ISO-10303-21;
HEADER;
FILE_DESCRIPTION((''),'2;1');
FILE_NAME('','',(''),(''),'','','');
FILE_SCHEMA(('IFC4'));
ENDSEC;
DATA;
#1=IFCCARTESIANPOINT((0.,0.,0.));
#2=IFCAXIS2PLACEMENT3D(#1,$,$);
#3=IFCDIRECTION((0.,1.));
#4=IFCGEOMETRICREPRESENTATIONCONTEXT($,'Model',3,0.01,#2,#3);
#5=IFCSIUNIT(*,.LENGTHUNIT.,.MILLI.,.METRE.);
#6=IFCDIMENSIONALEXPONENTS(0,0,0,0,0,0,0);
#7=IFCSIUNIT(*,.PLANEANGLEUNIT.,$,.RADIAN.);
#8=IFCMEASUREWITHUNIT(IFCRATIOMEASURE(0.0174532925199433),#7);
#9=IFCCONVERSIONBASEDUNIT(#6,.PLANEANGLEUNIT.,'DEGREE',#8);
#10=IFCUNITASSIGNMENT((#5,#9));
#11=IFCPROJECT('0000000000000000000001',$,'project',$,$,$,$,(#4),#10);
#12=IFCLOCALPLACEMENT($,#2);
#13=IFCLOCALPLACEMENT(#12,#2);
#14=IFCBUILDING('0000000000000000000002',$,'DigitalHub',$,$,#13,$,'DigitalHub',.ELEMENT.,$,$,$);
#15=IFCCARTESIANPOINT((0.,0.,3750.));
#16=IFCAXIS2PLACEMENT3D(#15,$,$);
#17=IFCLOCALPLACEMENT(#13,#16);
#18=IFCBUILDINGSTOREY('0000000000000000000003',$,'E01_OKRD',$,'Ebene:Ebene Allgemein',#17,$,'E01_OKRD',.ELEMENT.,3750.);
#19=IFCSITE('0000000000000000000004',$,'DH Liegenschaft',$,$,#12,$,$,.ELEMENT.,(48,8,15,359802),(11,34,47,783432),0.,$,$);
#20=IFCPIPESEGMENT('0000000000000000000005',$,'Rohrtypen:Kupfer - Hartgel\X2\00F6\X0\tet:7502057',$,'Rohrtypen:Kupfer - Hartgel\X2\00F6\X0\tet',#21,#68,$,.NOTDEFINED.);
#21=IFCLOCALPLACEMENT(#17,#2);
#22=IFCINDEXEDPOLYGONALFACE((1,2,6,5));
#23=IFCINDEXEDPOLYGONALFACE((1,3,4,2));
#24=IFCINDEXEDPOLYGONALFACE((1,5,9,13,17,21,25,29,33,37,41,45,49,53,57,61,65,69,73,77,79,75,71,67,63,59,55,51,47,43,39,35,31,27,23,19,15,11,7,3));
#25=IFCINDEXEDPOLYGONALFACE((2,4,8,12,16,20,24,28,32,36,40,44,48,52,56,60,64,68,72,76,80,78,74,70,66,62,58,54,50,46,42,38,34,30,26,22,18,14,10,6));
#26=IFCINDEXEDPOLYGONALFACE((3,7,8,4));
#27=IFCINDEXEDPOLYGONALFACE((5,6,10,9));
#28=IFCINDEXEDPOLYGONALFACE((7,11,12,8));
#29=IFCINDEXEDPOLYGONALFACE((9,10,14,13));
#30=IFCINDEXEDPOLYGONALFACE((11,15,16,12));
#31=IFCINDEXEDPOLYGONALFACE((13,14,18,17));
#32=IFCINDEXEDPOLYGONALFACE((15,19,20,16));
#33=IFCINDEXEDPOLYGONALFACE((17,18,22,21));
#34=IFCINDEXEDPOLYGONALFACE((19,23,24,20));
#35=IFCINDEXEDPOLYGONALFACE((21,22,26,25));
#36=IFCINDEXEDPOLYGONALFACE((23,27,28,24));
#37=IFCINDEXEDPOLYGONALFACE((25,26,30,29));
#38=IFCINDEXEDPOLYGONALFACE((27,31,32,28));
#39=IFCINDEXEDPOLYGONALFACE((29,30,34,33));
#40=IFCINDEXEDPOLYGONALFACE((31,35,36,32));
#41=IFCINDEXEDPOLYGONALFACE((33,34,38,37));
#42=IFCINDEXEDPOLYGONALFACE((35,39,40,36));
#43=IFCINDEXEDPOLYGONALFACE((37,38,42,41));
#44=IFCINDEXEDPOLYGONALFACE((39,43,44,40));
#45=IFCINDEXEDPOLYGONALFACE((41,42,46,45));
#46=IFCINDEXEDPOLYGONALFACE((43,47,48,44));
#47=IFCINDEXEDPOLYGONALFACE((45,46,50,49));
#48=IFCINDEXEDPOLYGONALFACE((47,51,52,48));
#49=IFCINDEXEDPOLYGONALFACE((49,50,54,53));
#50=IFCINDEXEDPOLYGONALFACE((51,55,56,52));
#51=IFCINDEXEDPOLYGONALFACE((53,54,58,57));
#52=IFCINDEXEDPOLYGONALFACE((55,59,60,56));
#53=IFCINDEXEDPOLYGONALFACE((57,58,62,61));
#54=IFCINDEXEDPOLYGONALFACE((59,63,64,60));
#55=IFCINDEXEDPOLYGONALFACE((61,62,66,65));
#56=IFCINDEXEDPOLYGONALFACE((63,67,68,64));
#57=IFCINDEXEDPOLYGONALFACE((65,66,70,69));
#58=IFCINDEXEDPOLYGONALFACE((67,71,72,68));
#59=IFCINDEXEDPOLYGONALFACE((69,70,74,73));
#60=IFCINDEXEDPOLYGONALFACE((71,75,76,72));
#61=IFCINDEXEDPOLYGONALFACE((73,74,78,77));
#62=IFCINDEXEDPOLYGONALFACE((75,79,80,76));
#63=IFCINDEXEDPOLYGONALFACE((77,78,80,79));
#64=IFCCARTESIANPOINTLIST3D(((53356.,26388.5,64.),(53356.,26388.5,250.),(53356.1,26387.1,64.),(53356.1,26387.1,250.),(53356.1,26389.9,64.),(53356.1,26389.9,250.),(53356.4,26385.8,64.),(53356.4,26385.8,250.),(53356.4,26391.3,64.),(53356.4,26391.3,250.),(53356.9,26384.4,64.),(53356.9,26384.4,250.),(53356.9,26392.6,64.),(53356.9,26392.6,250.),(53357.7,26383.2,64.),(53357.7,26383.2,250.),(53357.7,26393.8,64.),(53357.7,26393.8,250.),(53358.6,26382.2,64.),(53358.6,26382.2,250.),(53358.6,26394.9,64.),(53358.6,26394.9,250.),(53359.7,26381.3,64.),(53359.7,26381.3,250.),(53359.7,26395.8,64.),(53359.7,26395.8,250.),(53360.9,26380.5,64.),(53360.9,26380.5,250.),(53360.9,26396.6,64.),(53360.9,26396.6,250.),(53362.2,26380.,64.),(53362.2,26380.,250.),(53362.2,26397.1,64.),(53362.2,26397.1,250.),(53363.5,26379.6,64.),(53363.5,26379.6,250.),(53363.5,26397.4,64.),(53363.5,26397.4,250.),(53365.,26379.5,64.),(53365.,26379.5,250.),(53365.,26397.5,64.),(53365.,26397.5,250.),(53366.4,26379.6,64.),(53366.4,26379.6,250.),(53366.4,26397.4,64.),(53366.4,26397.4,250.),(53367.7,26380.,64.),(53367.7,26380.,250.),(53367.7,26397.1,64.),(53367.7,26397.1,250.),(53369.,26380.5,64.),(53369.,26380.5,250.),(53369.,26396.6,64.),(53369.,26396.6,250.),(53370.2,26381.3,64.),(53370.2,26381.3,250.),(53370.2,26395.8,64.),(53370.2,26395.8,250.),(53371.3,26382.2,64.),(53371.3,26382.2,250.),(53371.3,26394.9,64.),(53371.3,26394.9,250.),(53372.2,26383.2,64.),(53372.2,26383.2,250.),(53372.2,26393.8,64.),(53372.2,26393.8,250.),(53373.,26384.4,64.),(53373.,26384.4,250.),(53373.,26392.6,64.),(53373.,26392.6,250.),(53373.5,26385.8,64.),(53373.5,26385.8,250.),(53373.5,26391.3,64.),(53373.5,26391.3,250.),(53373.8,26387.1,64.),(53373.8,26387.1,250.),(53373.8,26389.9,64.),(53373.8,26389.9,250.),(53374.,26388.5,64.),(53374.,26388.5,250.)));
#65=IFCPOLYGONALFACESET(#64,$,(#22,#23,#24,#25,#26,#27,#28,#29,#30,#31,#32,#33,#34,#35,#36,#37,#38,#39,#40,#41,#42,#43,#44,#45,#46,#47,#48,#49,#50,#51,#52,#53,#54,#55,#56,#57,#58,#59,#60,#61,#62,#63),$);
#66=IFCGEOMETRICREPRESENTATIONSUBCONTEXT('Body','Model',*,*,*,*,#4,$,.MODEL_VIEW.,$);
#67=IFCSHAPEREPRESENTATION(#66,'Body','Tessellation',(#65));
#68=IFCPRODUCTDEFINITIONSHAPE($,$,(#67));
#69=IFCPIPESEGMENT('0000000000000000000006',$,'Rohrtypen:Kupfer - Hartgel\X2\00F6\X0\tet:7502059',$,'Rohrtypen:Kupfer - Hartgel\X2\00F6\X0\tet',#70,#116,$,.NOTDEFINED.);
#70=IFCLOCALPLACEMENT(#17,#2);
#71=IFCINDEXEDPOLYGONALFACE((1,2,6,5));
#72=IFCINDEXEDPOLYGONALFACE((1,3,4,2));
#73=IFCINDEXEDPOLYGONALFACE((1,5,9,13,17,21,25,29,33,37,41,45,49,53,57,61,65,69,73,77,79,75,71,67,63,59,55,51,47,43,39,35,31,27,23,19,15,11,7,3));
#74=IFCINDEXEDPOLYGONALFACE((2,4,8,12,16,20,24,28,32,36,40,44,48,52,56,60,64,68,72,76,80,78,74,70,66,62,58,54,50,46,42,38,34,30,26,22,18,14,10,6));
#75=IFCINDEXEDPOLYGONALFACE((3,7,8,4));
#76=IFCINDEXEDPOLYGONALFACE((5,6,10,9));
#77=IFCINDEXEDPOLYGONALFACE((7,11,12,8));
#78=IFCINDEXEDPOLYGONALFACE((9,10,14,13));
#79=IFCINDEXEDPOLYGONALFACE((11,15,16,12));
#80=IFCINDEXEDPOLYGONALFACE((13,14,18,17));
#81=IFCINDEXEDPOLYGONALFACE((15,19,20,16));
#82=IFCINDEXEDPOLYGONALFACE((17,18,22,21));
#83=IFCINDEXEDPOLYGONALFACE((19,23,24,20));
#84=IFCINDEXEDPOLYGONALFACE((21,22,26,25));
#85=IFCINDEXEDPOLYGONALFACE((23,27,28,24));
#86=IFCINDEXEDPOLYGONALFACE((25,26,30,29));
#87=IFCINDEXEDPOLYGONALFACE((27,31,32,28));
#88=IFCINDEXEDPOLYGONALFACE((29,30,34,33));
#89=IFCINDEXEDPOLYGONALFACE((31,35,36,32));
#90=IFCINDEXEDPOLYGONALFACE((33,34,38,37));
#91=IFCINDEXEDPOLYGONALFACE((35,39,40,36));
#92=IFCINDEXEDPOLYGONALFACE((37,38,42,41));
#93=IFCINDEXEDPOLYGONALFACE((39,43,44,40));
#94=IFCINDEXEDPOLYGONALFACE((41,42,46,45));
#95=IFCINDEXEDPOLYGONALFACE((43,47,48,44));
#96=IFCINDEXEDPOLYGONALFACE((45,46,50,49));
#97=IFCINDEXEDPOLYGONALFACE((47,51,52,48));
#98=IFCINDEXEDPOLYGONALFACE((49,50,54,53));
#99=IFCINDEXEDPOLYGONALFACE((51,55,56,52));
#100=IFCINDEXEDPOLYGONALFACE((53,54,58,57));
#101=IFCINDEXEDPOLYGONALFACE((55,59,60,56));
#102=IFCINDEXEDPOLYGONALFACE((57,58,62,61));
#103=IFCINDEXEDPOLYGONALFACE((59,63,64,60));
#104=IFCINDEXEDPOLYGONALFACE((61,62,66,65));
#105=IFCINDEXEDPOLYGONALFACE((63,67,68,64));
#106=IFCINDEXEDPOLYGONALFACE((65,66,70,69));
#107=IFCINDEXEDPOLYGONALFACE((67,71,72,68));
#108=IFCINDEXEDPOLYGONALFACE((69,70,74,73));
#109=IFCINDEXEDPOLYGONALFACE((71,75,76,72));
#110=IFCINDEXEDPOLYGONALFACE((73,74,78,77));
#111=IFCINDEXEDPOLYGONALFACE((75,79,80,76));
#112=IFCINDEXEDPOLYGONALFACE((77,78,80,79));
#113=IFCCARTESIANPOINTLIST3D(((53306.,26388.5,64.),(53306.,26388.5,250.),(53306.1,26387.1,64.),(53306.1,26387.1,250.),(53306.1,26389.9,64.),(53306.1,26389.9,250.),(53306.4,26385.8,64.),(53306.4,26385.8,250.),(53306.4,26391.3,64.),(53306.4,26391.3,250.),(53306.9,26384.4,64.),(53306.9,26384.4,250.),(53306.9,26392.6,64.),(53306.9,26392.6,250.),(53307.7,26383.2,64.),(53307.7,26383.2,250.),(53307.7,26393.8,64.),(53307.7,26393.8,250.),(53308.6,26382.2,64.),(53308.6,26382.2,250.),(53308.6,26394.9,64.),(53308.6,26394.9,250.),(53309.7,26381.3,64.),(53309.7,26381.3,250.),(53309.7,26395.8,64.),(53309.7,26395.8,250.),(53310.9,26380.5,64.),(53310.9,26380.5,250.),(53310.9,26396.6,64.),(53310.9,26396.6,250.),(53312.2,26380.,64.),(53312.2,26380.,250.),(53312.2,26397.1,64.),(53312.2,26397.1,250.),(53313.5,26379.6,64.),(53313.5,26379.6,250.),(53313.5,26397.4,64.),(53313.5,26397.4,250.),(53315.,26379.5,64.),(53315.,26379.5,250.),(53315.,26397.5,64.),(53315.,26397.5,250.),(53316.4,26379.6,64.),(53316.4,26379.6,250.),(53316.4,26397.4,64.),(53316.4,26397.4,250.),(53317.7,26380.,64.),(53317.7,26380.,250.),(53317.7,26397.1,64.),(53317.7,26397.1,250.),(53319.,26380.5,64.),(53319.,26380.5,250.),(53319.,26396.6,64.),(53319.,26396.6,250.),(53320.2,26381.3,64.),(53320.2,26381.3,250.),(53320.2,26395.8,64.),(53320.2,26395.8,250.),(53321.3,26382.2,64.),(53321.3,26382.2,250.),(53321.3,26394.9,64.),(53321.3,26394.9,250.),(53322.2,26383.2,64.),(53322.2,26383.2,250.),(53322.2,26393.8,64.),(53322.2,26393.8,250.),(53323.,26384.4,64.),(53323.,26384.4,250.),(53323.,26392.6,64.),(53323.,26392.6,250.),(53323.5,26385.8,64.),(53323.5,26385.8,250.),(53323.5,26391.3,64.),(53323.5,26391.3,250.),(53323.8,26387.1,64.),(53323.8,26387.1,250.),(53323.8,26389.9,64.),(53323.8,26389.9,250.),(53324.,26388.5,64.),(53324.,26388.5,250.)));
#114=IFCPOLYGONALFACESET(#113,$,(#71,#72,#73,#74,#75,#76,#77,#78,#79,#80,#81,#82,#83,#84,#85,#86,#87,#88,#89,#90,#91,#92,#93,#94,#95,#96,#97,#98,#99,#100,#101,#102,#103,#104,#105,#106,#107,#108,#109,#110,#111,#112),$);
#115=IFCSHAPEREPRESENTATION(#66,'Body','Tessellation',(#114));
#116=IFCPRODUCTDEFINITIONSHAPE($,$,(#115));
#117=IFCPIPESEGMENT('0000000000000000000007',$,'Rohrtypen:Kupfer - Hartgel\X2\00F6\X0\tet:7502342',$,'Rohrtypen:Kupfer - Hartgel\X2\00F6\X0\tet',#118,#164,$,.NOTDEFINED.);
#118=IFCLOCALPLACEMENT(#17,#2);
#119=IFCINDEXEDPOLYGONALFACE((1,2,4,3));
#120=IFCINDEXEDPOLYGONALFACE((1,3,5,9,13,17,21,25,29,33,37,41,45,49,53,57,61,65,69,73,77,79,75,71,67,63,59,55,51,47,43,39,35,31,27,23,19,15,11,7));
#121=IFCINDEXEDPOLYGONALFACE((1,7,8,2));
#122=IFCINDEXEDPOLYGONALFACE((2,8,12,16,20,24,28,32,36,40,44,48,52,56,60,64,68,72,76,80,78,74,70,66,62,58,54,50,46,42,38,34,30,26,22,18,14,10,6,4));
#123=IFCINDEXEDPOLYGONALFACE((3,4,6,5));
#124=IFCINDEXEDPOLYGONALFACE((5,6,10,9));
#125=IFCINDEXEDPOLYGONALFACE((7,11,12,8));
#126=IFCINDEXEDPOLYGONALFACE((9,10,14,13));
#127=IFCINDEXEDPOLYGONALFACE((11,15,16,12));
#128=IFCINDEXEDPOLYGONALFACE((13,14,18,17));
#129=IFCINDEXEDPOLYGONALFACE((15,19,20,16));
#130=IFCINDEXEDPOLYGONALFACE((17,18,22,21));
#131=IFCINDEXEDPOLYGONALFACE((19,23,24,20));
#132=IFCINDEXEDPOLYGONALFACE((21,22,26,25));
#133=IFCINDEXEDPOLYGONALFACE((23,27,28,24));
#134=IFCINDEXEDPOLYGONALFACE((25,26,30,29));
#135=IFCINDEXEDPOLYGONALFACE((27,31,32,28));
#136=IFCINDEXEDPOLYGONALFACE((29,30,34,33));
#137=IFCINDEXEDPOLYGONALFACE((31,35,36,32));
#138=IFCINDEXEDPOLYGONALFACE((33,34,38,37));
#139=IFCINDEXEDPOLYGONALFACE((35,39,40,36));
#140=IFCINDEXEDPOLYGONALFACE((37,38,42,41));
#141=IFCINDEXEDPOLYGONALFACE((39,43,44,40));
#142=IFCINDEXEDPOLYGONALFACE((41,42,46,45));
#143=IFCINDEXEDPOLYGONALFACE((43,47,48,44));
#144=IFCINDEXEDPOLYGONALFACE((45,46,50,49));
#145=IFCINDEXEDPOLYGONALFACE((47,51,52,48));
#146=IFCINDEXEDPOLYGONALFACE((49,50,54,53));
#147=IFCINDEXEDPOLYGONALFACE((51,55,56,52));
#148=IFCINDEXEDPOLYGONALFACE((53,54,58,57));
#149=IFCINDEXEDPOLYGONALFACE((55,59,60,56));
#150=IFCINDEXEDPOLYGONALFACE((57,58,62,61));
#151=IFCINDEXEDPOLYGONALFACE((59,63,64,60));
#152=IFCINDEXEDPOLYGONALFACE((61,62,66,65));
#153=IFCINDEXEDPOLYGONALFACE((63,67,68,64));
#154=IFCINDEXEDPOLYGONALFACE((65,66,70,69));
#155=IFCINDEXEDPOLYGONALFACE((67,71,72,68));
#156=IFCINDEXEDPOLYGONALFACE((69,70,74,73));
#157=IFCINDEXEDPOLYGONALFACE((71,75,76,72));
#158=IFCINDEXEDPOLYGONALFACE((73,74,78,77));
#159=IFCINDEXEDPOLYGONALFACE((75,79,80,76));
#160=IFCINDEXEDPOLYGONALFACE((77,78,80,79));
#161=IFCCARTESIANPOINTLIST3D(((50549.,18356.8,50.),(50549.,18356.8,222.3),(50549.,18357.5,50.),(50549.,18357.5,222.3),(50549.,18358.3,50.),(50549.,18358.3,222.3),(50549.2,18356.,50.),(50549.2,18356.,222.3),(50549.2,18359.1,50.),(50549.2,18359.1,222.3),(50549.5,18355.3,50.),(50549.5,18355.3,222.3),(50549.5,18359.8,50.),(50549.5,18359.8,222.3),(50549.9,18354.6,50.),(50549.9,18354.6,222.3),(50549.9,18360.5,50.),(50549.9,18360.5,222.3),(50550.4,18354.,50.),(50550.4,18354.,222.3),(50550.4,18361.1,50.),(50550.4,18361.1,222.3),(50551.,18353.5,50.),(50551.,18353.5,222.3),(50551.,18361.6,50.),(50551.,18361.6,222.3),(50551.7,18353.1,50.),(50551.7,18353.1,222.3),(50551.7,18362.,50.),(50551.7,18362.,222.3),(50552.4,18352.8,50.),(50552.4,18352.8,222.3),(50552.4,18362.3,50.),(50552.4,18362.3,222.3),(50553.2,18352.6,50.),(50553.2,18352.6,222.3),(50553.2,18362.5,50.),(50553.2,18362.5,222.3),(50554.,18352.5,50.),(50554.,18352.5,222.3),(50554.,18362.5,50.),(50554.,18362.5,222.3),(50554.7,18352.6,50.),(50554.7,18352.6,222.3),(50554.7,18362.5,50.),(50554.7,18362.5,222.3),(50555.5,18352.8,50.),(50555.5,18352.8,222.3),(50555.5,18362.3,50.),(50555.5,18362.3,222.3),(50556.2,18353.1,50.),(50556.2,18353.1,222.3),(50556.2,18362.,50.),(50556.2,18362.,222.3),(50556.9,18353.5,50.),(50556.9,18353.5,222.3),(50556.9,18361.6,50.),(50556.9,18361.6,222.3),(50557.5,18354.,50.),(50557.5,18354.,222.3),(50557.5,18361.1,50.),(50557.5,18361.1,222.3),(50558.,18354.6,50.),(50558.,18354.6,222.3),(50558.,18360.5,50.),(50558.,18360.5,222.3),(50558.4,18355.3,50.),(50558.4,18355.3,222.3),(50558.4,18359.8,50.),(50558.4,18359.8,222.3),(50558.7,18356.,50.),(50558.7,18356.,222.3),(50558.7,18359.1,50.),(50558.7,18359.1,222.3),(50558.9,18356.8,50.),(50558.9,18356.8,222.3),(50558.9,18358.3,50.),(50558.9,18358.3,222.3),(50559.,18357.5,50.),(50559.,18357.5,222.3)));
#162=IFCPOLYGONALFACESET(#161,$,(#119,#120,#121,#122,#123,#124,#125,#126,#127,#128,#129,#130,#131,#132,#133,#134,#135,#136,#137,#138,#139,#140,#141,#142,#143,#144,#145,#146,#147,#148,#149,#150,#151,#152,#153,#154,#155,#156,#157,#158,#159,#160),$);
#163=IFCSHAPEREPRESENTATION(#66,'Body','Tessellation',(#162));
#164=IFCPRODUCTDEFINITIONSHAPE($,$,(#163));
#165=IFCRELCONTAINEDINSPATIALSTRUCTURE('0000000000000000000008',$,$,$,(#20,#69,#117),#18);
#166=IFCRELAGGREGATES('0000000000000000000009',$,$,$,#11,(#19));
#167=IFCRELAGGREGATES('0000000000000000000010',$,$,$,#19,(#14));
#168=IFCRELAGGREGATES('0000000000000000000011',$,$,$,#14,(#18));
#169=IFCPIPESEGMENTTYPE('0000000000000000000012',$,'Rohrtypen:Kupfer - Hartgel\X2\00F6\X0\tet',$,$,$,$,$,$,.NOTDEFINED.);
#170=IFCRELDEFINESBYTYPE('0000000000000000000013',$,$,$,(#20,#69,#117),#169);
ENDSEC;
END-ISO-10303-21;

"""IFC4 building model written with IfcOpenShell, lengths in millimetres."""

from ifc_helpers import new_model, entity, si_unit, converted_unit, direction, frame, origin, place, context, subcontext, project, spatial, indexed_curve, outline, extrude, type_object, element, save


model = new_model("IFC4")

# Units and contexts
model_context = context("Model", 3, precision=0.01, world=origin(), true_north=direction((0.0, 1.0)))
body_context = subcontext(model_context, "Body", "Model", "MODEL_VIEW")
ifc_project = project(units=[si_unit("LENGTHUNIT", "METRE", prefix="MILLI"), converted_unit("PLANEANGLEUNIT", "DEGREE", entity("IfcRatioMeasure", 0.0174532925199433), si_unit("PLANEANGLEUNIT", "RADIAN"), dimensions=[0, 0, 0, 0, 0, 0, 0])], contexts=[model_context])

# Site, building, storey
site_placement = place(None, origin())
site = spatial("IfcSite", under=ifc_project, at=site_placement, Name="DH Liegenschaft", CompositionType="ELEMENT", RefLatitude=(48, 8, 15, 359802), RefLongitude=(11, 34, 47, 783432), RefElevation=0.0)
building_placement = place(site_placement, origin())
building = spatial("IfcBuilding", under=site, at=building_placement, Name="DigitalHub", LongName="DigitalHub", CompositionType="ELEMENT")
storey_placement = place(building_placement, frame((0.0, 0.0, 3750.0)))
storey = spatial("IfcBuildingStorey", under=building, at=storey_placement, Name="E01_OKRD", ObjectType="Ebene:Ebene Allgemein", LongName="E01_OKRD", CompositionType="ELEMENT", Elevation=3750.0)

# Pipe segments
pipe_segment_type = type_object("IfcPipeSegmentType", Name="Rohrtypen:Kupfer - Hartgelötet", PredefinedType="NOTDEFINED")
pipe_segment_1_placement = place(storey_placement, frame((53354.4, 26377.9, 64.0)))
element("IfcPipeSegment", 1, at=pipe_segment_1_placement, inside=storey, type_object=pipe_segment_type, Name="Rohrtypen:Kupfer - Hartgelötet:7502057", ObjectType="Rohrtypen:Kupfer - Hartgelötet", PredefinedType="NOTDEFINED", context=body_context, shape_type="SweptSolid", body=[
    extrude(outline(indexed_curve([(9.0, 0.0), (8.9, 1.4), (8.6, 2.8), (8.0, 4.1), (7.3, 5.3), (6.4, 6.4), (5.3, 7.3), (4.1, 8.0), (2.8, 8.6), (1.4, 8.9), (0.0, 9.0), (-1.4, 8.9), (-2.8, 8.6), (-4.1, 8.0), (-5.3, 7.3), (-6.4, 6.4), (-7.3, 5.3), (-8.0, 4.1), (-8.6, 2.8), (-8.9, 1.4), (-9.0, 0.0), (-8.9, -1.4), (-8.6, -2.8), (-8.0, -4.1), (-7.3, -5.3), (-6.4, -6.4), (-5.3, -7.3), (-4.1, -8.0), (-2.8, -8.6), (-1.4, -8.9), (0.0, -9.0), (1.4, -8.9), (2.8, -8.6), (4.1, -8.0), (5.3, -7.3), (6.4, -6.4), (7.3, -5.3), (8.0, -4.1), (8.6, -2.8), (8.9, -1.4), (9.0, 0.0)], self_intersect=False)), frame((10.6, 10.6, 0.0)), (0.0, 0.0, 1.0), 186.0),
])
pipe_segment_2_placement = place(storey_placement, frame((53304.4, 26377.9, 64.0)))
element("IfcPipeSegment", 2, at=pipe_segment_2_placement, inside=storey, type_object=pipe_segment_type, Name="Rohrtypen:Kupfer - Hartgelötet:7502059", ObjectType="Rohrtypen:Kupfer - Hartgelötet", PredefinedType="NOTDEFINED", context=body_context, shape_type="SweptSolid", body=[
    extrude(outline(indexed_curve([(9.0, 0.0), (8.9, 1.4), (8.6, 2.8), (8.0, 4.1), (7.3, 5.3), (6.4, 6.4), (5.3, 7.3), (4.1, 8.0), (2.8, 8.6), (1.4, 8.9), (0.0, 9.0), (-1.4, 8.9), (-2.8, 8.6), (-4.1, 8.0), (-5.3, 7.3), (-6.4, 6.4), (-7.3, 5.3), (-8.0, 4.1), (-8.6, 2.8), (-8.9, 1.4), (-9.0, 0.0), (-8.9, -1.4), (-8.6, -2.8), (-8.0, -4.1), (-7.3, -5.3), (-6.4, -6.4), (-5.3, -7.3), (-4.1, -8.0), (-2.8, -8.6), (-1.4, -8.9), (0.0, -9.0), (1.4, -8.9), (2.8, -8.6), (4.1, -8.0), (5.3, -7.3), (6.4, -6.4), (7.3, -5.3), (8.0, -4.1), (8.6, -2.8), (8.9, -1.4), (9.0, 0.0)], self_intersect=False)), frame((10.6, 10.6, 0.0)), (0.0, 0.0, 1.0), 186.0),
])
pipe_segment_3_placement = place(storey_placement, frame((50547.4, 18350.9, 50.0)))
element("IfcPipeSegment", 3, at=pipe_segment_3_placement, inside=storey, type_object=pipe_segment_type, Name="Rohrtypen:Kupfer - Hartgelötet:7502342", ObjectType="Rohrtypen:Kupfer - Hartgelötet", PredefinedType="NOTDEFINED", context=body_context, shape_type="SweptSolid", body=[
    extrude(outline(indexed_curve([(5.0, 0.0), (4.9, 0.8), (4.8, 1.5), (4.5, 2.3), (4.0, 2.9), (3.5, 3.5), (2.9, 4.0), (2.3, 4.5), (1.5, 4.8), (0.8, 4.9), (0.0, 5.0), (-0.8, 4.9), (-1.5, 4.8), (-2.3, 4.5), (-2.9, 4.0), (-3.5, 3.5), (-4.0, 2.9), (-4.5, 2.3), (-4.8, 1.5), (-4.9, 0.8), (-5.0, 0.0), (-4.9, -0.8), (-4.8, -1.5), (-4.5, -2.3), (-4.0, -2.9), (-3.5, -3.5), (-2.9, -4.0), (-2.3, -4.5), (-1.5, -4.8), (-0.8, -4.9), (0.0, -5.0), (0.8, -4.9), (1.5, -4.8), (2.3, -4.5), (2.9, -4.0), (3.5, -3.5), (4.0, -2.9), (4.5, -2.3), (4.8, -1.5), (4.9, -0.8), (5.0, 0.0)], self_intersect=False)), frame((6.6, 6.6, 0.0)), (0.0, 0.0, 1.0), 172.3),
])

save(model, "model.ifc")
